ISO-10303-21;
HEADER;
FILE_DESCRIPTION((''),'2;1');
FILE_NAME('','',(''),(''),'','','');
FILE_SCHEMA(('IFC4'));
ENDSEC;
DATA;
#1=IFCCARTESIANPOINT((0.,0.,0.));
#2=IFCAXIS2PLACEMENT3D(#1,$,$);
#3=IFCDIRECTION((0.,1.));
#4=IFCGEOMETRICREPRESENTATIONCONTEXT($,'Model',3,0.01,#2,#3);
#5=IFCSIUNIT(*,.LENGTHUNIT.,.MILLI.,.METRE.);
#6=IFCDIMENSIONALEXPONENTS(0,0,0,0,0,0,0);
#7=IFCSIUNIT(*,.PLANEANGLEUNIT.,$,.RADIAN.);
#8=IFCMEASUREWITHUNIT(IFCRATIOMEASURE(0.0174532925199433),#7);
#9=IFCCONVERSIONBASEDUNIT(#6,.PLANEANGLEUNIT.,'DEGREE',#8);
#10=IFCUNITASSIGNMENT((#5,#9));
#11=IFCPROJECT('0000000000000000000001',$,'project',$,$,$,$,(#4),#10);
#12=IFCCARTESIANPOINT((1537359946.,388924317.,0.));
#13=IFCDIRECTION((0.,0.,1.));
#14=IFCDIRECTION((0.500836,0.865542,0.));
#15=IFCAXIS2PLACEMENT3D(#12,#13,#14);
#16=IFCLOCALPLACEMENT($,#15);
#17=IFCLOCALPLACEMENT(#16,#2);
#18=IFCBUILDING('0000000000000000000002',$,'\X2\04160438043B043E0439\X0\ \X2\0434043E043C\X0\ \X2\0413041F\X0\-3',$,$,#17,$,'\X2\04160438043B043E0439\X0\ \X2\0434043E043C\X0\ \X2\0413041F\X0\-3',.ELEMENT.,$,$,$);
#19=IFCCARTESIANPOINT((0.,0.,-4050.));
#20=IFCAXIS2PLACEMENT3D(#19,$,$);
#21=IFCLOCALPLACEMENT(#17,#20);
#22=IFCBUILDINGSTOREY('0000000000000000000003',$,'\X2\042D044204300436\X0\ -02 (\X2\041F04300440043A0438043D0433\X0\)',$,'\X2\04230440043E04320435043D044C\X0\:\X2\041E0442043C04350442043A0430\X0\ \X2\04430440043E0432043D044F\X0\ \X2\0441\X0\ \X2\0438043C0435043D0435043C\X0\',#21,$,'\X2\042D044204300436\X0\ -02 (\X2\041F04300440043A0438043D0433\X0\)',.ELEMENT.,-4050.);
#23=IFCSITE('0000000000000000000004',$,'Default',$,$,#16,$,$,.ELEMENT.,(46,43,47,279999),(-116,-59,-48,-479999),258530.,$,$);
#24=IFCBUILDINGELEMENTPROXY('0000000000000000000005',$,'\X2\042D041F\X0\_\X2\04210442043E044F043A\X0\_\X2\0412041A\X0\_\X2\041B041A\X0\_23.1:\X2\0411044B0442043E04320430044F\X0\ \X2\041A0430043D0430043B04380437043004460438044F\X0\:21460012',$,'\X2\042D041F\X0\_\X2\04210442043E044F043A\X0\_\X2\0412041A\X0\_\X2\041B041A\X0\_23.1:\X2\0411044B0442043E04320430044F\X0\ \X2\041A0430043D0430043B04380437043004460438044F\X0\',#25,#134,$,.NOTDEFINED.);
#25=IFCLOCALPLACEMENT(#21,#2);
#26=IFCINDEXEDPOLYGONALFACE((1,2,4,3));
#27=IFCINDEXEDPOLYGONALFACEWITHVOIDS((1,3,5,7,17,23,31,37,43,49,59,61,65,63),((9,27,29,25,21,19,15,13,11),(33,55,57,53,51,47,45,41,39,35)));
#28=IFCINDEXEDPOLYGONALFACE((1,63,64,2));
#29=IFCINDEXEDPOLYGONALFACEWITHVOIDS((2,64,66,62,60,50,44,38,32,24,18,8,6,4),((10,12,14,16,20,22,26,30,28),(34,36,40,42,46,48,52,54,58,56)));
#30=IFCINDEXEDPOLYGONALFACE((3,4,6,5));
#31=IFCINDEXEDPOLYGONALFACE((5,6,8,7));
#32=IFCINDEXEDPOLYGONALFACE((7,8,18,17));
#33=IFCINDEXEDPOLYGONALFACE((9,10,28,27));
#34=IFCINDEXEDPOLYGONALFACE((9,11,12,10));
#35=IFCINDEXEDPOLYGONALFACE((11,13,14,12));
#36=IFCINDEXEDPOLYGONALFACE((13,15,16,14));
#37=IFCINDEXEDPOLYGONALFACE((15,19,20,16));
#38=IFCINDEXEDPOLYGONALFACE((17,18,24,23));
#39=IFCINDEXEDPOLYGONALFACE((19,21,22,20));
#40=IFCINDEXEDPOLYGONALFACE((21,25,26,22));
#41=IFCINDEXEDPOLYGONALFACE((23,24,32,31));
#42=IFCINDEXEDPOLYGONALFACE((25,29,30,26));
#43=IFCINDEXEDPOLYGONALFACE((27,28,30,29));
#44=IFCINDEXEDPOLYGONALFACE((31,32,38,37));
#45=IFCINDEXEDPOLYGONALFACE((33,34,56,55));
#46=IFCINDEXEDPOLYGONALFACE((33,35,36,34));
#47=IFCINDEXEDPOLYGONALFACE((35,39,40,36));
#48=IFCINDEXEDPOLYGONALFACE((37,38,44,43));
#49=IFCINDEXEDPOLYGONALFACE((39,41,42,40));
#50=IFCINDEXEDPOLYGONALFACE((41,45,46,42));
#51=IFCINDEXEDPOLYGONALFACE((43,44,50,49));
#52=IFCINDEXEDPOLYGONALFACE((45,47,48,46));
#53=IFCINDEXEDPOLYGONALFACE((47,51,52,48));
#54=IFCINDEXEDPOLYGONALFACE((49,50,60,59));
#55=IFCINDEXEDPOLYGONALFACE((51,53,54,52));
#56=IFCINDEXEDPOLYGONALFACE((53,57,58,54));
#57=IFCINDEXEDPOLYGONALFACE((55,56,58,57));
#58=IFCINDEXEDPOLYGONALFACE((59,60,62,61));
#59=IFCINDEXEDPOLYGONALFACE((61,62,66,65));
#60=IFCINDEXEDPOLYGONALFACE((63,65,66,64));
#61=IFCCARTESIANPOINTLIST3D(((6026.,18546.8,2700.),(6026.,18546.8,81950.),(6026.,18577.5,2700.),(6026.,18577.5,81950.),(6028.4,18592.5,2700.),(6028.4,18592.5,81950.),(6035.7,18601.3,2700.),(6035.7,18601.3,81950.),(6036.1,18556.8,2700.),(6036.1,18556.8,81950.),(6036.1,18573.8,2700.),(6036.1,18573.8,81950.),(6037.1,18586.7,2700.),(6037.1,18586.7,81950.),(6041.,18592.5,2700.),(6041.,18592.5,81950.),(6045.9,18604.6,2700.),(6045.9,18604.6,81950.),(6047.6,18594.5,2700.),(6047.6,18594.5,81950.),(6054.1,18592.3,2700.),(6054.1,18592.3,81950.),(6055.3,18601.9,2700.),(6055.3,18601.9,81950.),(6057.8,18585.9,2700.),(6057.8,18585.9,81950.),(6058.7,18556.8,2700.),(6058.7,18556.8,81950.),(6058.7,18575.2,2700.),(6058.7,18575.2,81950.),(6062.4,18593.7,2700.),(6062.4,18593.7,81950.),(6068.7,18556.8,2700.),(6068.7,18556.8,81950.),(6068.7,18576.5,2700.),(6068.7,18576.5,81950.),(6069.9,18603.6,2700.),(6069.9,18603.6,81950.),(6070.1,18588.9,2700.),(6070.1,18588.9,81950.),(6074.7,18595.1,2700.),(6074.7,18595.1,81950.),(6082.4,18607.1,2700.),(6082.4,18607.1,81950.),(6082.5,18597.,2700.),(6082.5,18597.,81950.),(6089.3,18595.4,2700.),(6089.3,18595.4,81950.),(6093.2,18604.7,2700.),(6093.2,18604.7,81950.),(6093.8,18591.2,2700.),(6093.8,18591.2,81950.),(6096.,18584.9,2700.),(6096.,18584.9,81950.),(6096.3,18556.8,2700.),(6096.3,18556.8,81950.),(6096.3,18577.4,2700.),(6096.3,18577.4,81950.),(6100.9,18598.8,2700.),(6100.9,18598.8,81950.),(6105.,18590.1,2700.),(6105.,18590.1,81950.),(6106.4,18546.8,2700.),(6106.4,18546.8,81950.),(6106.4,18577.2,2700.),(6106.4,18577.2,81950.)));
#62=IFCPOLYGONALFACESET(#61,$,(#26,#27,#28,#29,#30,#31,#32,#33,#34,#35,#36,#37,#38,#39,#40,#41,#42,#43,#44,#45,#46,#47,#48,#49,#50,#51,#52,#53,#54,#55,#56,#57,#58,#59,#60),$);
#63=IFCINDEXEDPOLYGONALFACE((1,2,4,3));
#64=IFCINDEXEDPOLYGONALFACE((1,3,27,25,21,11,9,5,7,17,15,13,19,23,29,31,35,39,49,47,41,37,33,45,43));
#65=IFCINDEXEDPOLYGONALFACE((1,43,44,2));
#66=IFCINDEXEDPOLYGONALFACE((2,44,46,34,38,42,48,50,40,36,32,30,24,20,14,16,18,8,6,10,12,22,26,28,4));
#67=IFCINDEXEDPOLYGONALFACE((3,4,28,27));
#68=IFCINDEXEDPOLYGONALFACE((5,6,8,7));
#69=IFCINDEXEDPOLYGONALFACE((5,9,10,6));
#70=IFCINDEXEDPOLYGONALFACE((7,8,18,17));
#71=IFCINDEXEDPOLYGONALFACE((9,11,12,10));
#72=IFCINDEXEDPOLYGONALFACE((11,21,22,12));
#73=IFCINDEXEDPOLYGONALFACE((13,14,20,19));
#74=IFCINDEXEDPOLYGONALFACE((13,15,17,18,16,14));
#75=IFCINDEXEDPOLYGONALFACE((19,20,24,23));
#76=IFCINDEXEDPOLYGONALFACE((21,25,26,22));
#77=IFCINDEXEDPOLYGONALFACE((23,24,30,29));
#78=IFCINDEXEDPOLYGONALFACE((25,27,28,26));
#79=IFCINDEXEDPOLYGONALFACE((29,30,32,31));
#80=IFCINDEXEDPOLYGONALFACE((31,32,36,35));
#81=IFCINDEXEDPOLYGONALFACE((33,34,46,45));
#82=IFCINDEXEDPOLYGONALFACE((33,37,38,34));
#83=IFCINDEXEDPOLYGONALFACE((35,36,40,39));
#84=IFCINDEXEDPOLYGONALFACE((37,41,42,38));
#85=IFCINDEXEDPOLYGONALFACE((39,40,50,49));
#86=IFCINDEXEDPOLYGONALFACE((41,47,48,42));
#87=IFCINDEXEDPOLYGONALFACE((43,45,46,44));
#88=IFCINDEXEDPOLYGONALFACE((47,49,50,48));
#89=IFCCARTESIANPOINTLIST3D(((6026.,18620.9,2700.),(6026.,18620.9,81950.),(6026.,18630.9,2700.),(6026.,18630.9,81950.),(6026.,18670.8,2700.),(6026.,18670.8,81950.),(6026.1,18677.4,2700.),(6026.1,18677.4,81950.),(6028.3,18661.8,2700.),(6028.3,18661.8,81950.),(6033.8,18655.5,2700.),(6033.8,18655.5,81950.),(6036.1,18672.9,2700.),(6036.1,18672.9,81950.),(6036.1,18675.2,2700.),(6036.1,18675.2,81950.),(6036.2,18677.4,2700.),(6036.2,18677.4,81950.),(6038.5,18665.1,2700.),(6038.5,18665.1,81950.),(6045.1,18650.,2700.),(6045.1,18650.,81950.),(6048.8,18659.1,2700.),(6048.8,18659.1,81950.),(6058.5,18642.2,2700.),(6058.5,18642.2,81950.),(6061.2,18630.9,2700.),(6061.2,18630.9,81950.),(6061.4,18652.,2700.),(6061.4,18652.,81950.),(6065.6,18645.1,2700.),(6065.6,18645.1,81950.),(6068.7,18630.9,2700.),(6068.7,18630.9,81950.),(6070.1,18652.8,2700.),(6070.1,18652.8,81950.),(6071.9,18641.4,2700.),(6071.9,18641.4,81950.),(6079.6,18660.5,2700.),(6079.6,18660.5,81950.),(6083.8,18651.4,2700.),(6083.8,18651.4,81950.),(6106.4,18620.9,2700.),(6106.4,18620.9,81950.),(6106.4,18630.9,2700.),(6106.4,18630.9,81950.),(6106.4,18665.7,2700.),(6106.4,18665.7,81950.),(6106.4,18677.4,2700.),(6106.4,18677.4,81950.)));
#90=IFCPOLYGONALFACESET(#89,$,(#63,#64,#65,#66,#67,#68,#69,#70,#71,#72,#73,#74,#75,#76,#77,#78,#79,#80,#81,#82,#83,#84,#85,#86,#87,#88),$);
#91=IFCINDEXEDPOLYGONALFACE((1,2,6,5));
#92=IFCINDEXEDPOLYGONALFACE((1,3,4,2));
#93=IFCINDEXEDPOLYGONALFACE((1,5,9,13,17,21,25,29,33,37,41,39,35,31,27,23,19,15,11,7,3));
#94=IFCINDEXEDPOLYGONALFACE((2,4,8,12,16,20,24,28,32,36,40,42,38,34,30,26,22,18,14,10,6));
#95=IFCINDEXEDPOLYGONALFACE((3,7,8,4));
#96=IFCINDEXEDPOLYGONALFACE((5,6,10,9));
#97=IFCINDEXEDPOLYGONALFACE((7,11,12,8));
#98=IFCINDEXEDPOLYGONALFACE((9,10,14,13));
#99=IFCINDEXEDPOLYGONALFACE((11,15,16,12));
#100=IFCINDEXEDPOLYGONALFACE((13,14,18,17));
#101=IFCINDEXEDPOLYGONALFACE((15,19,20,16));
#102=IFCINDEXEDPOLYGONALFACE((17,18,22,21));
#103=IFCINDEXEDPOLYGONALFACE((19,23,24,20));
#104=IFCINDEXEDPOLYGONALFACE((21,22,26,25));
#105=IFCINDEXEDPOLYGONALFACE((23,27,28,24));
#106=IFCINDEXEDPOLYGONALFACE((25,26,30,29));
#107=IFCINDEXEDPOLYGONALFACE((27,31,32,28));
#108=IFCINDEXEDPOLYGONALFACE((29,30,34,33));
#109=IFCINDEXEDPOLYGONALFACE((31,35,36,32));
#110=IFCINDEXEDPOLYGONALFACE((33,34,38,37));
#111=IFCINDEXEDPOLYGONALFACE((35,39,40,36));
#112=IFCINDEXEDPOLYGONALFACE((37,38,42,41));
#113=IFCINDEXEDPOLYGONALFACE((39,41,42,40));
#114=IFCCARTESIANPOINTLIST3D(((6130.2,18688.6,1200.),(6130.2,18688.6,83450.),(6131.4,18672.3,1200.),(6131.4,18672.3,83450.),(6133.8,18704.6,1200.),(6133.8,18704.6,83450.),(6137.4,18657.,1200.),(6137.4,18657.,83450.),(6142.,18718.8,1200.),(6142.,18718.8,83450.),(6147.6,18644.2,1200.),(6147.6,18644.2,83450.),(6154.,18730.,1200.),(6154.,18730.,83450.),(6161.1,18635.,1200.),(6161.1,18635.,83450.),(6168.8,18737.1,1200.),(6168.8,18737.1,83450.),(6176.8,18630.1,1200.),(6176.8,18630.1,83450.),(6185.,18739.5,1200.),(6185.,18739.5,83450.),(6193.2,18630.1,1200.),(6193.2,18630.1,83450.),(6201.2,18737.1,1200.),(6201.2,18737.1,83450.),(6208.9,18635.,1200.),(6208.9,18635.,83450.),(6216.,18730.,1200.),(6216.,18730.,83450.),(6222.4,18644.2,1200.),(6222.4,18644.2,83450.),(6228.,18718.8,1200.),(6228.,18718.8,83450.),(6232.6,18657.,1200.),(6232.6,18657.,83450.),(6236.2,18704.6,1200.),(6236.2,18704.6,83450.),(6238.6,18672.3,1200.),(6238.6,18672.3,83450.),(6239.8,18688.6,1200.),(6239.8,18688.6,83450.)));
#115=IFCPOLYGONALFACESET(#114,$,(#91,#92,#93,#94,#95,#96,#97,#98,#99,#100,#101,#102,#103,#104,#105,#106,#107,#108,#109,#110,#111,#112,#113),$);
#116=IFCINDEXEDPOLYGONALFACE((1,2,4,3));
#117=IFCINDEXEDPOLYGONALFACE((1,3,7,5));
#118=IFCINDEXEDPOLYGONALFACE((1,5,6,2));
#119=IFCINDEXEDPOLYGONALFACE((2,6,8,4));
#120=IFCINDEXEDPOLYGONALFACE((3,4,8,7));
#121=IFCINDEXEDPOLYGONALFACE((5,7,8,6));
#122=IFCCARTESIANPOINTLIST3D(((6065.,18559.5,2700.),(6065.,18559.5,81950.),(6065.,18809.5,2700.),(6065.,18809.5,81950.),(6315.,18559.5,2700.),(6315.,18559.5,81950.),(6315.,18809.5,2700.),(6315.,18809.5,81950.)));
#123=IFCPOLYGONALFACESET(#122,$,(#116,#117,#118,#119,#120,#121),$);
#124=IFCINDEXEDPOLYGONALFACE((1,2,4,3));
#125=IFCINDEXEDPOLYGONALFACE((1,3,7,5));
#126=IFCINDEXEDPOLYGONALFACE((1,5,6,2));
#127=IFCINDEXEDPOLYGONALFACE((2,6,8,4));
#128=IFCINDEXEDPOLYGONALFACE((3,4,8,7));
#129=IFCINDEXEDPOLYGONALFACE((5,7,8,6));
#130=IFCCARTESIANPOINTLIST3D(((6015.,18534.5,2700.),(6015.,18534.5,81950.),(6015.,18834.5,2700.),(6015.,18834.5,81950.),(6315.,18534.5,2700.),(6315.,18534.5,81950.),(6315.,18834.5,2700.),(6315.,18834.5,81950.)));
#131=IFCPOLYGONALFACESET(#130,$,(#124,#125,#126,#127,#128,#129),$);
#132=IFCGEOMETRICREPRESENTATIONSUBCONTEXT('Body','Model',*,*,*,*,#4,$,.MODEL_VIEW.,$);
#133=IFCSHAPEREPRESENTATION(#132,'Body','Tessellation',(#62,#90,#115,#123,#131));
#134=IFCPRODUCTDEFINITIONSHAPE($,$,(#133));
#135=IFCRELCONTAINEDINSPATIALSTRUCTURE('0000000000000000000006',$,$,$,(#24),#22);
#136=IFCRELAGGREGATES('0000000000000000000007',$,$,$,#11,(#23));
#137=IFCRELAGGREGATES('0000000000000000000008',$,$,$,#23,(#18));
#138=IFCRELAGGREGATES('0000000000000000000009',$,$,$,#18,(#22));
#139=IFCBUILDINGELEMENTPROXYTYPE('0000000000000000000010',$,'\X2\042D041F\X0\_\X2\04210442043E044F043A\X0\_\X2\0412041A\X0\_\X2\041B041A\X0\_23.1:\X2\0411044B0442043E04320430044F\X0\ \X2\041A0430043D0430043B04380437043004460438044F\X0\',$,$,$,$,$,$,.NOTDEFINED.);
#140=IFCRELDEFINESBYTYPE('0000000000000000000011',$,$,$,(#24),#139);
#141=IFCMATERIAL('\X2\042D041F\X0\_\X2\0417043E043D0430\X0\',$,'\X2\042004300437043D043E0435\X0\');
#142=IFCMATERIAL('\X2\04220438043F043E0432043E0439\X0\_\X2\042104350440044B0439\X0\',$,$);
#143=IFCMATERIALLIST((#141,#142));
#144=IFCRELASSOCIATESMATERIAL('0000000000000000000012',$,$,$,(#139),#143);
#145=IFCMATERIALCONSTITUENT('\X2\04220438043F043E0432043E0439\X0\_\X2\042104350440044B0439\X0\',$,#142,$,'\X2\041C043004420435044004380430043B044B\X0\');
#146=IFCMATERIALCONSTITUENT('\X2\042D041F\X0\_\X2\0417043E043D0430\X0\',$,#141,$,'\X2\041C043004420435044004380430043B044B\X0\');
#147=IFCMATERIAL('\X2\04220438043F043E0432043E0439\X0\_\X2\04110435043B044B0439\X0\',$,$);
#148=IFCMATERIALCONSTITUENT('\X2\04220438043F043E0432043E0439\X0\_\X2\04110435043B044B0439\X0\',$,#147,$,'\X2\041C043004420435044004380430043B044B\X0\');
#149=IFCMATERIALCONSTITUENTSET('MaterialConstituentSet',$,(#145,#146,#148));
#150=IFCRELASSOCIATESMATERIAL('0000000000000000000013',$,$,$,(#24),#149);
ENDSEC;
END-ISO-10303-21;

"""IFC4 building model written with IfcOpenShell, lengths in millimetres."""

from ifc_helpers import new_model, entity, si_unit, converted_unit, direction, frame, frame_2d, origin, place, context, subcontext, project, spatial, polyline, rectangle, circle, outline, extrude, source, transform, mapped, material, material_list, constituent, constituent_set, type_object, type_shapes, element, save


model = new_model("IFC4")

# Units and contexts
model_context = context("Model", 3, precision=0.01, world=origin(), true_north=direction((0.0, 1.0)))
body_context = subcontext(model_context, "Body", "Model", "MODEL_VIEW")
ifc_project = project(units=[si_unit("LENGTHUNIT", "METRE", prefix="MILLI"), converted_unit("PLANEANGLEUNIT", "DEGREE", entity("IfcRatioMeasure", 0.0174532925199433), si_unit("PLANEANGLEUNIT", "RADIAN"), dimensions=[0, 0, 0, 0, 0, 0, 0])], contexts=[model_context])

# Site, building, storey
site_placement = place(None, frame((1537359946.0, 388924317.0, 0.0), z_axis=(0.0, 0.0, 1.0), x_axis=(0.500836, 0.865542, 0.0)))
site = spatial("IfcSite", under=ifc_project, at=site_placement, Name="Default", CompositionType="ELEMENT", RefLatitude=(46, 43, 47, 279999), RefLongitude=(-116, -59, -48, -479999), RefElevation=258530.0)
building_placement = place(site_placement, origin())
building = spatial("IfcBuilding", under=site, at=building_placement, Name="Жилой дом ГП-3", LongName="Жилой дом ГП-3", CompositionType="ELEMENT")
storey_placement = place(building_placement, frame((0.0, 0.0, -4050.0)))
storey = spatial("IfcBuildingStorey", under=building, at=storey_placement, Name="Этаж -02 (Паркинг)", ObjectType="Уровень:Отметка уровня с именем", LongName="Этаж -02 (Паркинг)", CompositionType="ELEMENT", Elevation=-4050.0)

# Building element proxy
ifc_material_1 = material(Name="ЭП_Зона", Category="Разное")
ifc_material_2 = material(Name="Типовой_Белый")
ifc_material_3 = material(Name="Типовой_Серый")
ifc_material_list_1 = material_list([ifc_material_1, ifc_material_3])
building_element_proxy_type_1 = type_object("IfcBuildingElementProxyType", Name="ЭП_Стояк_ВК_ЛК_23.1:Бытовая Канализация", PredefinedType="NOTDEFINED", material=ifc_material_list_1)
shared_shape_1 = source(origin(), body_context, "Body", "SweptSolid", [
    extrude(outline(polyline([(-42.2, -39.0), (-11.8, -39.0), (1.1, -37.6), (9.8, -33.5), (15.7, -25.8), (18.0, -15.0), (14.6, -2.5), (4.7, 5.0), (12.8, 12.1), (15.5, 21.5), (12.3, 31.8), (3.4, 39.0), (-11.6, 41.4), (-42.2, 41.4), (-42.2, -39.0)]), holes=[polyline([(-32.2, 8.8), (-32.2, 31.4), (-15.2, 31.4), (-2.3, 30.3), (3.5, 26.4), (5.5, 19.9), (3.3, 13.3), (-3.1, 9.6), (-13.9, 8.8), (-32.2, 8.8)]), polyline([(-32.2, -28.9), (-32.2, -1.3), (-12.6, -1.3), (-0.2, -2.6), (6.1, -7.3), (8.0, -15.1), (6.3, -21.9), (2.2, -26.3), (-4.1, -28.5), (-11.6, -28.9), (-32.2, -28.9)])]), frame((54.5, -52.4, -1350.0)), (0.0, 0.0, 1.0), 79250.0),
    extrude(outline(polyline([(-32.1, -31.9), (48.3, -31.9), (48.3, -21.8), (10.6, -21.8), (13.8, -11.4), (25.6, -1.3), (48.3, 13.0), (48.3, 24.6), (21.4, 7.7), (12.0, 0.1), (7.4, -7.7), (3.3, -0.7), (-9.3, 6.4), (-19.7, 12.3), (-22.1, 20.2), (-22.0, 22.4), (-22.0, 24.6), (-32.0, 24.6), (-32.1, 18.0), (-29.9, 9.0), (-24.3, 2.8), (-13.1, -2.8), (0.4, -10.6), (3.0, -21.8), (-32.1, -21.8), (-32.1, -31.9)])), frame((118.2, -43.1, -1350.0), z_axis=(0.0, 0.0, 1.0), x_axis=(0.0, -1.0, 0.0)), (0.0, 0.0, 1.0), 79250.0),
    extrude(circle(Radius=55.0, at=frame_2d((0.0, 0.0), x_axis=(1.0, 0.0))), frame((150.0, -170.0, -2850.0)), (0.0, 0.0, 1.0), 82250.0),
    extrude(rectangle(XDim=250.0, YDim=250.0, at=frame_2d((0.0, 0.0), x_axis=(1.0, 0.0))), frame((150.0, -175.0, -1350.0)), (0.0, 0.0, 1.0), 79250.0),
    extrude(rectangle(XDim=300.0, YDim=300.0, at=frame_2d((0.0, 0.0), x_axis=(1.0, 0.0))), frame((150.0, -150.0, -1350.0)), (0.0, 0.0, 1.0), 79250.0),
])
type_shapes(building_element_proxy_type_1, [shared_shape_1])
ifc_constituent_1 = constituent(ifc_material_3, Name="Типовой_Серый", Category="Материалы")
ifc_constituent_2 = constituent(ifc_material_1, Name="ЭП_Зона", Category="Материалы")
ifc_constituent_3 = constituent(ifc_material_2, Name="Типовой_Белый", Category="Материалы")
ifc_constituent_set_1 = constituent_set(constituents=[ifc_constituent_1, ifc_constituent_2, ifc_constituent_3], Name="MaterialConstituentSet")
proxy_1_placement = place(storey_placement, frame((6015.0, 18534.5, 4050.0), z_axis=(0.0, 0.0, 1.0), x_axis=(0.0, 1.0, 0.0)))
element("IfcBuildingElementProxy", 1, at=proxy_1_placement, inside=storey, type_object=building_element_proxy_type_1, material=ifc_constituent_set_1, Name="ЭП_Стояк_ВК_ЛК_23.1:Бытовая Канализация:21460012", ObjectType="ЭП_Стояк_ВК_ЛК_23.1:Бытовая Канализация", PredefinedType="NOTDEFINED", context=body_context, shape_type="MappedRepresentation", body=[
    mapped(shared_shape_1, transform((0.0, 0.0, 0.0), scale=1.0)),
])

save(model, "model.ifc")
